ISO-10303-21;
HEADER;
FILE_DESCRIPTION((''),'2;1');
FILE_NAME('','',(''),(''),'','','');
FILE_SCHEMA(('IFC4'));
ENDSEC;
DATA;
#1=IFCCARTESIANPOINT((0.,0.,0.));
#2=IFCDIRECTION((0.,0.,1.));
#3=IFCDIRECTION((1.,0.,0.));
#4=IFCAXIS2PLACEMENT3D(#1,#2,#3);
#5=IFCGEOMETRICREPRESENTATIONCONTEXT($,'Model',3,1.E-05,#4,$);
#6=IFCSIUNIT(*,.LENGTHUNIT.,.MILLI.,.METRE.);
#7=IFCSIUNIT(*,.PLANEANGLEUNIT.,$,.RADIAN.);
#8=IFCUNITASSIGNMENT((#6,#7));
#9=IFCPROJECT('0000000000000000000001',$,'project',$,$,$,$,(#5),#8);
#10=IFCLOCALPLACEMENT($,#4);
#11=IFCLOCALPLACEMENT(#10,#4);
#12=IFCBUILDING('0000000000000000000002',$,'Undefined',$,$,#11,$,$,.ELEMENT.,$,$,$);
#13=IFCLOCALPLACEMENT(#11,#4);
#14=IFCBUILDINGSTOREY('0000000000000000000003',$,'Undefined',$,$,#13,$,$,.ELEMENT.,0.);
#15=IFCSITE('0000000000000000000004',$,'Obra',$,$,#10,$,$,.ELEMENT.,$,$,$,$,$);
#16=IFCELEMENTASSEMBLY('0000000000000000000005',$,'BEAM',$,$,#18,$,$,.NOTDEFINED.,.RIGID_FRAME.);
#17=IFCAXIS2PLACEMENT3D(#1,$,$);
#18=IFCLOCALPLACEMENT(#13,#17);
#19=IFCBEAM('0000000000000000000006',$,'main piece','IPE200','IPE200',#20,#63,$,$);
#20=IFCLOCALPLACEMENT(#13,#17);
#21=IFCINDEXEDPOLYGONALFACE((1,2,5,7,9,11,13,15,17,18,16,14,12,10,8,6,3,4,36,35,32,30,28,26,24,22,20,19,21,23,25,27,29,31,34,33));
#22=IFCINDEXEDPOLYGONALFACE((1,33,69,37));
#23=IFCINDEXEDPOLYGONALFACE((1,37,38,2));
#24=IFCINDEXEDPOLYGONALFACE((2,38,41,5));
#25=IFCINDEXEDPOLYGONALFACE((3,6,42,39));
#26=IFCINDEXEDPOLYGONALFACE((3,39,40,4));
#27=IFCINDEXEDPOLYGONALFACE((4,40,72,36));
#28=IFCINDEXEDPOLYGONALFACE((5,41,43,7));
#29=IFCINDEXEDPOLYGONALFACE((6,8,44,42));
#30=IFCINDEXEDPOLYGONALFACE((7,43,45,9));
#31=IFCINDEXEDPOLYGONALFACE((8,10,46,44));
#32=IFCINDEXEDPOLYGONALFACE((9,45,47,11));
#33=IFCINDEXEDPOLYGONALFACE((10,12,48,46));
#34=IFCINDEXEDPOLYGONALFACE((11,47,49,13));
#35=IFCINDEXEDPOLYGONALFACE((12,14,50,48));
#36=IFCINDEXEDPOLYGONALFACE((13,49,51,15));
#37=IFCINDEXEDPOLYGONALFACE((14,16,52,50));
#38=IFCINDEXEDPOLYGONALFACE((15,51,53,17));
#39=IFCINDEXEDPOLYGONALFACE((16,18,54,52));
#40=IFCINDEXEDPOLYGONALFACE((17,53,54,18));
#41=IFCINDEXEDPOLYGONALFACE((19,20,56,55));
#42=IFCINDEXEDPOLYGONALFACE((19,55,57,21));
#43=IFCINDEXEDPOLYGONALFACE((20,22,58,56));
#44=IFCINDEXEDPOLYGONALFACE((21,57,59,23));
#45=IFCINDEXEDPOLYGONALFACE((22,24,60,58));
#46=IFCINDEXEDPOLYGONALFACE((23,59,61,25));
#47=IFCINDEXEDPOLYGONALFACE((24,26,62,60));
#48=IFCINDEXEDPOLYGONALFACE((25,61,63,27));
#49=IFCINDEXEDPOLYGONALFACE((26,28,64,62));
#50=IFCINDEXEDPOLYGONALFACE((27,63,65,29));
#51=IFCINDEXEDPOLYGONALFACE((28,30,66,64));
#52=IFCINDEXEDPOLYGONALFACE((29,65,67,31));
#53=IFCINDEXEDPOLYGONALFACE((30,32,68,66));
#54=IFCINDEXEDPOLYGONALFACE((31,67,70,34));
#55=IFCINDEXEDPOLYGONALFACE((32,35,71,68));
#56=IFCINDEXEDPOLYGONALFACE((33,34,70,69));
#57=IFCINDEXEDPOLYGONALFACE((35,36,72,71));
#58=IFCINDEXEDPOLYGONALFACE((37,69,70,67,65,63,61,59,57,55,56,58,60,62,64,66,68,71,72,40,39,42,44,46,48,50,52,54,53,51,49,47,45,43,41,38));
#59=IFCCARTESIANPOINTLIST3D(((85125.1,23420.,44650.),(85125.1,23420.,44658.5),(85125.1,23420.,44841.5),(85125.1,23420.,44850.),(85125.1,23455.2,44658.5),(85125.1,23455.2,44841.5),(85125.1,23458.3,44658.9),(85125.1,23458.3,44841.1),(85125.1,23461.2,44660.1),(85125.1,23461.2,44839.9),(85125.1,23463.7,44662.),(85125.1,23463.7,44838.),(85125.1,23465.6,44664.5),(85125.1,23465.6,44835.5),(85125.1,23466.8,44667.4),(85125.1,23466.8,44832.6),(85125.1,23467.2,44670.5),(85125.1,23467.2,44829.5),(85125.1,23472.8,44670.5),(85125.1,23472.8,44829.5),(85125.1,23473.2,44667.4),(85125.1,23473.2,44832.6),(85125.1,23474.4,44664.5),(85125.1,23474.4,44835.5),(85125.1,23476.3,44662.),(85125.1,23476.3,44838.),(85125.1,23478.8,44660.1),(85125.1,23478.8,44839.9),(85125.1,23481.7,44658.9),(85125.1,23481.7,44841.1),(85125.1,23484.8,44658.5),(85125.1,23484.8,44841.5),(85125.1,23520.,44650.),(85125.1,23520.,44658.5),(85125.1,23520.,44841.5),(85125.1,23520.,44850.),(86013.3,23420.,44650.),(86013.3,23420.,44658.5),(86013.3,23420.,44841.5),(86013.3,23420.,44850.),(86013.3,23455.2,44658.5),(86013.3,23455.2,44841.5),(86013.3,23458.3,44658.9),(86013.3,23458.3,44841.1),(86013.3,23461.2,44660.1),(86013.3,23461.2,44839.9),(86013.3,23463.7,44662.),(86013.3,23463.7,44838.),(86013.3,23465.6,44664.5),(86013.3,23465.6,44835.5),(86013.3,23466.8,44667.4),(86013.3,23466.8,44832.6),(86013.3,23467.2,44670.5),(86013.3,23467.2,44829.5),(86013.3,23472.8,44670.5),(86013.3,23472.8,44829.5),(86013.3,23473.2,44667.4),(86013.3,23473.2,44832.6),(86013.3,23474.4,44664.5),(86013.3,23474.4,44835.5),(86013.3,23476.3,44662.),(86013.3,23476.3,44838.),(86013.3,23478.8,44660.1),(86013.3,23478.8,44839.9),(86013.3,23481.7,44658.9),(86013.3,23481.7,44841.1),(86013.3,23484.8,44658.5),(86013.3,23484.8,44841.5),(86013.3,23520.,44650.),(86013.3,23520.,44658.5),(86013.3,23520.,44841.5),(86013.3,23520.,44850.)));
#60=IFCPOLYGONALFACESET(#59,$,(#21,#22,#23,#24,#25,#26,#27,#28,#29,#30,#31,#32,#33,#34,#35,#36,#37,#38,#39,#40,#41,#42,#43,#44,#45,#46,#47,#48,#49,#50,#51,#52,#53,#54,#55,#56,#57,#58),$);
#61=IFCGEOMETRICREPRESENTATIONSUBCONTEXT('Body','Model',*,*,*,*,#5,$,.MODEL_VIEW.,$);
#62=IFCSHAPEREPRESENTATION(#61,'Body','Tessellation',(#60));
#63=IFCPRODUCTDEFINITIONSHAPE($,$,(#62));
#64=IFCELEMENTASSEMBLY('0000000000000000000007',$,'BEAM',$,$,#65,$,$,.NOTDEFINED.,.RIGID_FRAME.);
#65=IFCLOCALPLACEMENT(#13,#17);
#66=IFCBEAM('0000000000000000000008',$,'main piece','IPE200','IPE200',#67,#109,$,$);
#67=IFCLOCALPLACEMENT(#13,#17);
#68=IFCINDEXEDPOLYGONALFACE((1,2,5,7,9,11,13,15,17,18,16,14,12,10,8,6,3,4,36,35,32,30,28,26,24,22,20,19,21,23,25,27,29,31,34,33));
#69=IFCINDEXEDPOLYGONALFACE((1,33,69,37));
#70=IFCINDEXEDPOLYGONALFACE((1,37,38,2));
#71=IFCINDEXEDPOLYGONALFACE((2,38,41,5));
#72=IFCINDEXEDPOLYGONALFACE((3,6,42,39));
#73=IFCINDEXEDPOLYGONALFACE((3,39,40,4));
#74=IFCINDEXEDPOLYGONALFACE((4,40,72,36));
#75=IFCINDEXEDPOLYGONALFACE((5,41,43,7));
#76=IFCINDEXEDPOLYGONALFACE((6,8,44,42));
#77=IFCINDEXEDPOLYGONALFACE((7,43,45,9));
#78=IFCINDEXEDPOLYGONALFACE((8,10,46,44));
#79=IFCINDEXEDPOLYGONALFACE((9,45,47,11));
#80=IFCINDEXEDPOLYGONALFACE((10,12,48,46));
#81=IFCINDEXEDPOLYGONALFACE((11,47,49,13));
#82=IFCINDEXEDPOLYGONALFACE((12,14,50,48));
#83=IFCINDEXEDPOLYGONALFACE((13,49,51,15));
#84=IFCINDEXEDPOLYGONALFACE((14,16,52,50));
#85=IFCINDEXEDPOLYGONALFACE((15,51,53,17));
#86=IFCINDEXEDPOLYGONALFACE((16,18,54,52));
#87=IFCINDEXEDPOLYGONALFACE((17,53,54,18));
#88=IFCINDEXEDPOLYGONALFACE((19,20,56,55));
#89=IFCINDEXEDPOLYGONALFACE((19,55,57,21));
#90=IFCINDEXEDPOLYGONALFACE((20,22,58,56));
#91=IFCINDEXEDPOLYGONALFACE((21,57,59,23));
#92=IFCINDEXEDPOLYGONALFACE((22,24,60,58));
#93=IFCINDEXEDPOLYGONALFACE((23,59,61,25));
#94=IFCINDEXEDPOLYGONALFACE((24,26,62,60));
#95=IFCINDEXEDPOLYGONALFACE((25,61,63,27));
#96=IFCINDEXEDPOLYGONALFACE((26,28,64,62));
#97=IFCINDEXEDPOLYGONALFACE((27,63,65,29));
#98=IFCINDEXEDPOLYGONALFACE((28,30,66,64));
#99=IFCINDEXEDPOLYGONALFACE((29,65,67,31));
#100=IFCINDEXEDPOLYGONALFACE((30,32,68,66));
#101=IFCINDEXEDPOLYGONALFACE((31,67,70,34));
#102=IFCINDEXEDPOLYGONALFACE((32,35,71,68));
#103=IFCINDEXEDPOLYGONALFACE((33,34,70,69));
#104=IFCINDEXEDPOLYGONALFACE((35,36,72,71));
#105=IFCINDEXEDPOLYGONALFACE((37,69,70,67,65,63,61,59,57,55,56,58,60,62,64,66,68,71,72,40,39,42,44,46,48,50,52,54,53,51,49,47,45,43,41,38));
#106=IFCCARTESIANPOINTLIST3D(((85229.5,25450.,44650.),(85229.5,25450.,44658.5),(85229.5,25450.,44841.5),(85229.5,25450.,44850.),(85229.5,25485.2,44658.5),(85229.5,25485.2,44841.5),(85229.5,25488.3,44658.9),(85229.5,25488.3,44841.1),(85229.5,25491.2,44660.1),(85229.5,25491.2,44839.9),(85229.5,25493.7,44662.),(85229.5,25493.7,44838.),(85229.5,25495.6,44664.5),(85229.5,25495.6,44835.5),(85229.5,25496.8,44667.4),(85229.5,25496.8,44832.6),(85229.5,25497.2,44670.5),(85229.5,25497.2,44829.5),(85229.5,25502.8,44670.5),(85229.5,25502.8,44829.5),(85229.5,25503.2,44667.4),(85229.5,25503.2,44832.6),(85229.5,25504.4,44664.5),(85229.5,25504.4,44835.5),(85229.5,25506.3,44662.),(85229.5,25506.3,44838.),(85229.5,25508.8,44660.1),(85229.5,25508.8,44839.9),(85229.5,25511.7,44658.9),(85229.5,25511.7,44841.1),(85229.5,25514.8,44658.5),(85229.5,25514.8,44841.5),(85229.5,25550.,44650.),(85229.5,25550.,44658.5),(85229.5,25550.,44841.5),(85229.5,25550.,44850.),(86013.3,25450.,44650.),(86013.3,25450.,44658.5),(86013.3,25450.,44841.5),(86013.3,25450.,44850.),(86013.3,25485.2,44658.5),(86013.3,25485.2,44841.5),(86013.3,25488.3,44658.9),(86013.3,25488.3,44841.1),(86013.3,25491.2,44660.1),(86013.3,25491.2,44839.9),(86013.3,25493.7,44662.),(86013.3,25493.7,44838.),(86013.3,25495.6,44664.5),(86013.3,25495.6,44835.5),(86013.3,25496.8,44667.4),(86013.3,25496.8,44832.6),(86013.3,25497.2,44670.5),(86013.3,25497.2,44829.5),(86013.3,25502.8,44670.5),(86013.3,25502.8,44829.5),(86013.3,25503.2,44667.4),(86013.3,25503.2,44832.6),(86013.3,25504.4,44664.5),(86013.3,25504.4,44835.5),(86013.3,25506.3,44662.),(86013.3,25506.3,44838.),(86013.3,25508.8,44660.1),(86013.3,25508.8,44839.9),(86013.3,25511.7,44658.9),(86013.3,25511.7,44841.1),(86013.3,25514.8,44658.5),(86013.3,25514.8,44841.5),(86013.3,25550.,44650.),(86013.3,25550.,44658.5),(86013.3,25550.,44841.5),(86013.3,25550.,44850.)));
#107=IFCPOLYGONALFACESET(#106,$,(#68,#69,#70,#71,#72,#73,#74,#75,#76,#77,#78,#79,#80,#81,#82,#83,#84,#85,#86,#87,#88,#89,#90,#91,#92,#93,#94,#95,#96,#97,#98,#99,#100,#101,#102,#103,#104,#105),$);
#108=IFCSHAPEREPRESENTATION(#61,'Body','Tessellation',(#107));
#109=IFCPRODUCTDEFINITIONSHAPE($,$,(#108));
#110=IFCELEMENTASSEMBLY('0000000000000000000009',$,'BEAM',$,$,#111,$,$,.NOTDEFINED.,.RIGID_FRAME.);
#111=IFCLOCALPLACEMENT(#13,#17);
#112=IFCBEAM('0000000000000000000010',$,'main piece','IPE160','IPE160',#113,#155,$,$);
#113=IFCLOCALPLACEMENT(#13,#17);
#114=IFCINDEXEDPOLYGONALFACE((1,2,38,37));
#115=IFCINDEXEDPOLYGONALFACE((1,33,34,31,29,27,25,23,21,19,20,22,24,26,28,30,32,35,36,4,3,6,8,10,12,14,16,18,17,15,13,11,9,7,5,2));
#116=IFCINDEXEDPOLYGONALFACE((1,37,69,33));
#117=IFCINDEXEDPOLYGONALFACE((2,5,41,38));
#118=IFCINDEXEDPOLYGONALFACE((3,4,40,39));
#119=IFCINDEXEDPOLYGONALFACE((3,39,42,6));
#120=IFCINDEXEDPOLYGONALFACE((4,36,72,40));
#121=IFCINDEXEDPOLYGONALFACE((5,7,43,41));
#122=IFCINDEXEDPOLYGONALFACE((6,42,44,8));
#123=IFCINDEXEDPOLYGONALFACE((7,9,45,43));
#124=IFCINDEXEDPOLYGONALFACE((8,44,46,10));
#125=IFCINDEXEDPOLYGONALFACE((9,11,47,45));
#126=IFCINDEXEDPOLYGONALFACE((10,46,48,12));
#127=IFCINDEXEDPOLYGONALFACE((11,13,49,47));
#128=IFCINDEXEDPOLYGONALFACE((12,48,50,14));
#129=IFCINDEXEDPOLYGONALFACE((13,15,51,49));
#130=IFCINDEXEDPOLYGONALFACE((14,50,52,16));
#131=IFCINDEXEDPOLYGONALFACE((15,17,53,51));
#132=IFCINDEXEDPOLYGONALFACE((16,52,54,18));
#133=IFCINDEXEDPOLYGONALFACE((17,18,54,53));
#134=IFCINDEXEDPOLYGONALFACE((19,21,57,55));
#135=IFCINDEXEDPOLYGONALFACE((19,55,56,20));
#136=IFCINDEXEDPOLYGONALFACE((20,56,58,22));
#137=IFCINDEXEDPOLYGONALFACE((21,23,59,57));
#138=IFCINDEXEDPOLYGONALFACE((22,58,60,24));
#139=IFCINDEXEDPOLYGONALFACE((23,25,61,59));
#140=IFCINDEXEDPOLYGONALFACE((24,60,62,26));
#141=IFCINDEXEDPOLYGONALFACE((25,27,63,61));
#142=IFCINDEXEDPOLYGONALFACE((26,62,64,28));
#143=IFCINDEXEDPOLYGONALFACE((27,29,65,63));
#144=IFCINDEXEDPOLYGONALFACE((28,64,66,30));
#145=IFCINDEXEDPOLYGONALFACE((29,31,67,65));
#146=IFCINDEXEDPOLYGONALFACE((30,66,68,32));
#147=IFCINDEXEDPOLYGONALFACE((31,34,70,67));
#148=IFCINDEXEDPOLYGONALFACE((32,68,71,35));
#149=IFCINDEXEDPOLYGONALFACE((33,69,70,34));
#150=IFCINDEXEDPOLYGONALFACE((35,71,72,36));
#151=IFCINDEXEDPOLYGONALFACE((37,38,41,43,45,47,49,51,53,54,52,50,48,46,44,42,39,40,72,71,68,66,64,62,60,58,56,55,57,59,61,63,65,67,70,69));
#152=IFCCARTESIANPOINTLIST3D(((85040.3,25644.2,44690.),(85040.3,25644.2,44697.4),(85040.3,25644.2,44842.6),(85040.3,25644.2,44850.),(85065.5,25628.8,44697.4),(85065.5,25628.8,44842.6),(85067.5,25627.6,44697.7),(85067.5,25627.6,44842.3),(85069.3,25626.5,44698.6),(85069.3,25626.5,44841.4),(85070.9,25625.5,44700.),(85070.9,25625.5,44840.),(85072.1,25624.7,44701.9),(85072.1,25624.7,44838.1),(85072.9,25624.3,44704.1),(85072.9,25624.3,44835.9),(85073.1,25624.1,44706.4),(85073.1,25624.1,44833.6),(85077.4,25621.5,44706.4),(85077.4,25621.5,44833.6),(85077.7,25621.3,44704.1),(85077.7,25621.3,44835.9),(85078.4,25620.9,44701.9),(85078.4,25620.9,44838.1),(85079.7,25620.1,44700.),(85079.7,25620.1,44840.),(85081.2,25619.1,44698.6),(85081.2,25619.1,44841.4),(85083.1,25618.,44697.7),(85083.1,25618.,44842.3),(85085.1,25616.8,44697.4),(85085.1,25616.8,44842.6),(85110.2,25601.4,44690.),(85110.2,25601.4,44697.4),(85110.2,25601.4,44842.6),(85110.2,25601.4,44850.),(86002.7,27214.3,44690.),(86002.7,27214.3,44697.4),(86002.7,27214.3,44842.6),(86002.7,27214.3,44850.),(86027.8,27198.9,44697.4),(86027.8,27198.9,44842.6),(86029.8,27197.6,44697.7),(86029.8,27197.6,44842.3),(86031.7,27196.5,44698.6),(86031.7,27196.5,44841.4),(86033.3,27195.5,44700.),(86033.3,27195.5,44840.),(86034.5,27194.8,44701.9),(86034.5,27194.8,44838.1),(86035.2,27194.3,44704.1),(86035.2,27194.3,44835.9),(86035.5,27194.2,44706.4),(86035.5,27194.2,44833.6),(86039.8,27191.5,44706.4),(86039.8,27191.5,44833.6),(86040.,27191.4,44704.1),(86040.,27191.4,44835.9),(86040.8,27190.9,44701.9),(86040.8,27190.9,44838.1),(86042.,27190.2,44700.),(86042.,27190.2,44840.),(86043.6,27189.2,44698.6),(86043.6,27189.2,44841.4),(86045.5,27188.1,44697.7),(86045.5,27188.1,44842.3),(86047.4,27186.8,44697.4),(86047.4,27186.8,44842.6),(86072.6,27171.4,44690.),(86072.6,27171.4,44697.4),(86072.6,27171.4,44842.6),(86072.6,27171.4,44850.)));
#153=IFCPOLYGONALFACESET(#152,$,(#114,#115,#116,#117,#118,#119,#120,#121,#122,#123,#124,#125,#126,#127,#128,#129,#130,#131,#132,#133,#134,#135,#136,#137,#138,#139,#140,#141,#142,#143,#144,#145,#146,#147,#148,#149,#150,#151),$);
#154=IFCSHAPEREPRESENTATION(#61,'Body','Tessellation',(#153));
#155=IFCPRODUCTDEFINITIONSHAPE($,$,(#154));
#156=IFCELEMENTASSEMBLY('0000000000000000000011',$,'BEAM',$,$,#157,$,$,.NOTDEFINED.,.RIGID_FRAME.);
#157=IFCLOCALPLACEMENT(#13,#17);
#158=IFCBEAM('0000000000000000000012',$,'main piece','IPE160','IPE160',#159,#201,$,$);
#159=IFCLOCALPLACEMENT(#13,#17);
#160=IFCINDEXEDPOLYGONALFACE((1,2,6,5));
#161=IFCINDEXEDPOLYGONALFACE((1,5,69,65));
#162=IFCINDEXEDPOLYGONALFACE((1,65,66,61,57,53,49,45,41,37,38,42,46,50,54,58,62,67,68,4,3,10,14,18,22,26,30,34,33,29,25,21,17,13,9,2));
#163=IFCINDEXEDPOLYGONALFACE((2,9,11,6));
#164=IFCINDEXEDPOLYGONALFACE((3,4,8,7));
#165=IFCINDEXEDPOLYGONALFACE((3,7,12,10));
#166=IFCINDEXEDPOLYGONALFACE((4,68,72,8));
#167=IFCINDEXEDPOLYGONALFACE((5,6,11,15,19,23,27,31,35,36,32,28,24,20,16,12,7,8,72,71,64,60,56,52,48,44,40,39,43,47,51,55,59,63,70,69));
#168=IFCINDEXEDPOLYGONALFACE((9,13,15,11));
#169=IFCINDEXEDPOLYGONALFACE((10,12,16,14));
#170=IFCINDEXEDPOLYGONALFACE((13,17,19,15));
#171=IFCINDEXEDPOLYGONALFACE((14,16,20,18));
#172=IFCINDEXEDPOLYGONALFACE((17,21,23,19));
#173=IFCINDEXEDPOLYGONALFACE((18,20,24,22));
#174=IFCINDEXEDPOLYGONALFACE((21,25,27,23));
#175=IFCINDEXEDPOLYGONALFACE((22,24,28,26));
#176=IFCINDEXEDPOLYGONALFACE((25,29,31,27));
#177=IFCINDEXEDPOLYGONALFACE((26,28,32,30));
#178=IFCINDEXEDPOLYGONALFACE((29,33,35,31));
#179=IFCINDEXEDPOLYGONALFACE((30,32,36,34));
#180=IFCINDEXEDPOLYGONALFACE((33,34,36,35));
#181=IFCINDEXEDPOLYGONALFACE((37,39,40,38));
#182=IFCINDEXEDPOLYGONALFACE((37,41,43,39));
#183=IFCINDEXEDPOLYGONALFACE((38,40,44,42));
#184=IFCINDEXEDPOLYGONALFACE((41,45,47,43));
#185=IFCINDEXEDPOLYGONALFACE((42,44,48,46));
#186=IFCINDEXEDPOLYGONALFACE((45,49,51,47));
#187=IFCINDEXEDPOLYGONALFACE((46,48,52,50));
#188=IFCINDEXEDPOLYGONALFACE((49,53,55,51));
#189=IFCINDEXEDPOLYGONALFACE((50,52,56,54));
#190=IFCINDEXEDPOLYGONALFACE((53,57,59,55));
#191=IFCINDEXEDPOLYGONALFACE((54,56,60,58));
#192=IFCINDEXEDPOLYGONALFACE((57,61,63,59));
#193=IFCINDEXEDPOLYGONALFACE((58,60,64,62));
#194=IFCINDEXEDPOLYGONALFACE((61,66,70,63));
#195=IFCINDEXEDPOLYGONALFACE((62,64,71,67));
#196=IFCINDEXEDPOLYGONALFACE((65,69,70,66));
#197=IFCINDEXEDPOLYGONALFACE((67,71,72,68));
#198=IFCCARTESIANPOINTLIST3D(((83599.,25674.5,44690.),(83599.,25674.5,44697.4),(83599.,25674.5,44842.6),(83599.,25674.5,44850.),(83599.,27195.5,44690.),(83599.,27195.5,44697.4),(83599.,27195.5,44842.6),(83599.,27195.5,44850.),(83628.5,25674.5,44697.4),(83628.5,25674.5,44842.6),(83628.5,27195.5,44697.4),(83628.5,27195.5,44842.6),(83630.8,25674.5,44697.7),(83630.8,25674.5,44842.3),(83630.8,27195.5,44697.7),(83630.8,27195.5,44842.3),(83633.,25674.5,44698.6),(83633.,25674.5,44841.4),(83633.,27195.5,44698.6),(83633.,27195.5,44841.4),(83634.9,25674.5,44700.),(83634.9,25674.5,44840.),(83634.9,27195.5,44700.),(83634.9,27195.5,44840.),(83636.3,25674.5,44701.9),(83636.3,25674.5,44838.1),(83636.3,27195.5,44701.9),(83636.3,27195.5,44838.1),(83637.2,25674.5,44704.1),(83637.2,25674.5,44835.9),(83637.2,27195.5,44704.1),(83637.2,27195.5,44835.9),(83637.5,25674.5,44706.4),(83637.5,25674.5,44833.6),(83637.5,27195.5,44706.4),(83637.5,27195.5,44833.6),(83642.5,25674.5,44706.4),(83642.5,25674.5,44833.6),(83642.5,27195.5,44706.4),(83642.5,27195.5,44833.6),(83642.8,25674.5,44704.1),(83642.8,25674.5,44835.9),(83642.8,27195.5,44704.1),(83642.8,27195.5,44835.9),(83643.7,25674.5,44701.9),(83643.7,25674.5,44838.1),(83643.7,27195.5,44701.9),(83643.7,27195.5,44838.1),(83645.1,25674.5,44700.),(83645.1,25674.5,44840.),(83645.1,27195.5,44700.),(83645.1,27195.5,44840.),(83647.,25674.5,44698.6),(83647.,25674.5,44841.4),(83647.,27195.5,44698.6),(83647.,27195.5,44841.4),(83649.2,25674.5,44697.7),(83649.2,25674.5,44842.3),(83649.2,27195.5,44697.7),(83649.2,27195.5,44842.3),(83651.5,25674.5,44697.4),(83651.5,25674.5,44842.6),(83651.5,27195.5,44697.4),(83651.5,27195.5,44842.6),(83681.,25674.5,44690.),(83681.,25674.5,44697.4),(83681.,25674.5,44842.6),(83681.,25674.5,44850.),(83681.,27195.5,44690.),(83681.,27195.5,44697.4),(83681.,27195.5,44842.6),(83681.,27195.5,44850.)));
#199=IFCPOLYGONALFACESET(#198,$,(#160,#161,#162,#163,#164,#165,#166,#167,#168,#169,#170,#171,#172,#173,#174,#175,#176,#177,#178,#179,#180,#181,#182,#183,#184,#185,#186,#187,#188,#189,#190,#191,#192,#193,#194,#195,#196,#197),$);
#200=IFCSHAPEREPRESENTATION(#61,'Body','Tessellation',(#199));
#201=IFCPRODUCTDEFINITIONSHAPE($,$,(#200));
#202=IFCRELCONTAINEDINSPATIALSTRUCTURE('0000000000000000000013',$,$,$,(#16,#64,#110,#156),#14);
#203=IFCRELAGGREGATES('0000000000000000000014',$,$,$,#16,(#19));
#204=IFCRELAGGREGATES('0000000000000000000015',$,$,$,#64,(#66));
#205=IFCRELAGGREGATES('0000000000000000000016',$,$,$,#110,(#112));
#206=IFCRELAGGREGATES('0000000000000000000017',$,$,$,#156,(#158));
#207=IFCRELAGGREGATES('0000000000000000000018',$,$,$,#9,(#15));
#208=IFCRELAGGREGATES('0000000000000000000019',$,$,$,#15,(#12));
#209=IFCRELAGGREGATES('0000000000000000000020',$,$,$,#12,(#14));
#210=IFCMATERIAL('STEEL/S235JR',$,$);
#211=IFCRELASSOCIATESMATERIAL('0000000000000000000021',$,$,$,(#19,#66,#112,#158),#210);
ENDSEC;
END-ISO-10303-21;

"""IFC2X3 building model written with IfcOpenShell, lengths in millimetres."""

from ifc_helpers import new_model, si_unit, frame, origin_with_axes, origin_2d_with_axis, place, context, subcontext, project, spatial, i_section, extrude, material, element, aggregate, save


model = new_model("IFC2X3")

# Units and contexts
model_context = context("Model", 3, precision=1e-05, world=origin_with_axes())
body_context = subcontext(model_context, "Body", "Model", "MODEL_VIEW")
ifc_project = project(units=[si_unit("LENGTHUNIT", "METRE", prefix="MILLI"), si_unit("PLANEANGLEUNIT", "RADIAN")], contexts=[model_context])

# Site, building, storey
site_placement = place(None, origin_with_axes())
site = spatial("IfcSite", under=ifc_project, at=site_placement, Name="Obra", CompositionType="ELEMENT")
building_placement = place(site_placement, origin_with_axes())
building = spatial("IfcBuilding", under=site, at=building_placement, Name="Undefined", CompositionType="ELEMENT")
storey_placement = place(building_placement, origin_with_axes())
storey = spatial("IfcBuildingStorey", under=building, at=storey_placement, Name="Undefined", CompositionType="ELEMENT", Elevation=0.0)

# Shared definitions
ifc_material = material(Name="STEEL/S235JR")

# Element assemblies, beams
assembly_1_placement = place(storey_placement, origin_with_axes())
assembly_1 = element("IfcElementAssembly", 1, at=assembly_1_placement, inside=storey, Name="BEAM", AssemblyPlace="NOTDEFINED", PredefinedType="RIGID_FRAME")
beam_1_placement = place(assembly_1_placement, frame((85125.0, 23470.0, 44750.0), z_axis=(0.0, 0.0, 1.0), x_axis=(1.0, 0.0, 0.0)))
beam_1 = element("IfcBeam", 2, at=beam_1_placement, material=ifc_material, Name="main piece", Description="IPE200", ObjectType="IPE200", context=body_context, shape_type="SweptSolid", body=[
    extrude(i_section(OverallWidth=100.0, OverallDepth=200.0, WebThickness=5.6, FlangeThickness=8.5, FilletRadius=12.0, at=origin_2d_with_axis()), frame((888.3, 0.0, 0.0), z_axis=(-1.0, 0.0, 0.0), x_axis=(0.0, -1.0, 0.0)), (0.0, 0.0, 1.0), 888.2),
])
aggregate(assembly_1, [beam_1])
assembly_2_placement = place(storey_placement, origin_with_axes())
assembly_2 = element("IfcElementAssembly", 3, at=assembly_2_placement, inside=storey, Name="BEAM", AssemblyPlace="NOTDEFINED", PredefinedType="RIGID_FRAME")
beam_2_placement = place(assembly_2_placement, frame((85229.5, 25500.0, 44750.0), z_axis=(0.0, 0.0, 1.0), x_axis=(1.0, 0.0, 0.0)))
beam_2 = element("IfcBeam", 4, at=beam_2_placement, material=ifc_material, Name="main piece", Description="IPE200", ObjectType="IPE200", context=body_context, shape_type="SweptSolid", body=[
    extrude(i_section(OverallWidth=100.0, OverallDepth=200.0, WebThickness=5.6, FlangeThickness=8.5, FilletRadius=12.0, at=origin_2d_with_axis()), frame((783.8, 0.0, 0.0), z_axis=(-1.0, 0.0, 0.0), x_axis=(0.0, -1.0, 0.0)), (0.0, 0.0, 1.0), 783.8),
])
aggregate(assembly_2, [beam_2])
assembly_3_placement = place(storey_placement, origin_with_axes())
assembly_3 = element("IfcElementAssembly", 5, at=assembly_3_placement, inside=storey, Name="BEAM", AssemblyPlace="NOTDEFINED", PredefinedType="RIGID_FRAME")
beam_3_placement = place(assembly_3_placement, frame((85075.3, 25622.8, 44770.0), z_axis=(0.0, 0.0, 1.0), x_axis=(0.522594, 0.852582, 0.0)))
beam_3 = element("IfcBeam", 6, at=beam_3_placement, material=ifc_material, Name="main piece", Description="IPE160", ObjectType="IPE160", context=body_context, shape_type="SweptSolid", body=[
    extrude(i_section(OverallWidth=82.0, OverallDepth=160.0, WebThickness=5.0, FlangeThickness=7.4, FilletRadius=9.0, at=origin_2d_with_axis()), frame((1841.5, 0.0, 0.0), z_axis=(-1.0, 0.0, 0.0), x_axis=(0.0, -1.0, 0.0)), (0.0, 0.0, 1.0), 1841.5),
])
aggregate(assembly_3, [beam_3])
assembly_4_placement = place(storey_placement, origin_with_axes())
assembly_4 = element("IfcElementAssembly", 7, at=assembly_4_placement, inside=storey, Name="BEAM", AssemblyPlace="NOTDEFINED", PredefinedType="RIGID_FRAME")
beam_4_placement = place(assembly_4_placement, frame((83640.0, 25674.5, 44770.0), z_axis=(0.0, 0.0, 1.0), x_axis=(0.000003, 1.0, 0.0)))
beam_4 = element("IfcBeam", 8, at=beam_4_placement, material=ifc_material, Name="main piece", Description="IPE160", ObjectType="IPE160", context=body_context, shape_type="SweptSolid", body=[
    extrude(i_section(OverallWidth=82.0, OverallDepth=160.0, WebThickness=5.0, FlangeThickness=7.4, FilletRadius=9.0, at=origin_2d_with_axis()), frame((1521.0, 0.0, 0.0), z_axis=(-1.0, 0.0, 0.0), x_axis=(0.0, -1.0, 0.0)), (0.0, 0.0, 1.0), 1521.0),
])
aggregate(assembly_4, [beam_4])

save(model, "model.ifc")
